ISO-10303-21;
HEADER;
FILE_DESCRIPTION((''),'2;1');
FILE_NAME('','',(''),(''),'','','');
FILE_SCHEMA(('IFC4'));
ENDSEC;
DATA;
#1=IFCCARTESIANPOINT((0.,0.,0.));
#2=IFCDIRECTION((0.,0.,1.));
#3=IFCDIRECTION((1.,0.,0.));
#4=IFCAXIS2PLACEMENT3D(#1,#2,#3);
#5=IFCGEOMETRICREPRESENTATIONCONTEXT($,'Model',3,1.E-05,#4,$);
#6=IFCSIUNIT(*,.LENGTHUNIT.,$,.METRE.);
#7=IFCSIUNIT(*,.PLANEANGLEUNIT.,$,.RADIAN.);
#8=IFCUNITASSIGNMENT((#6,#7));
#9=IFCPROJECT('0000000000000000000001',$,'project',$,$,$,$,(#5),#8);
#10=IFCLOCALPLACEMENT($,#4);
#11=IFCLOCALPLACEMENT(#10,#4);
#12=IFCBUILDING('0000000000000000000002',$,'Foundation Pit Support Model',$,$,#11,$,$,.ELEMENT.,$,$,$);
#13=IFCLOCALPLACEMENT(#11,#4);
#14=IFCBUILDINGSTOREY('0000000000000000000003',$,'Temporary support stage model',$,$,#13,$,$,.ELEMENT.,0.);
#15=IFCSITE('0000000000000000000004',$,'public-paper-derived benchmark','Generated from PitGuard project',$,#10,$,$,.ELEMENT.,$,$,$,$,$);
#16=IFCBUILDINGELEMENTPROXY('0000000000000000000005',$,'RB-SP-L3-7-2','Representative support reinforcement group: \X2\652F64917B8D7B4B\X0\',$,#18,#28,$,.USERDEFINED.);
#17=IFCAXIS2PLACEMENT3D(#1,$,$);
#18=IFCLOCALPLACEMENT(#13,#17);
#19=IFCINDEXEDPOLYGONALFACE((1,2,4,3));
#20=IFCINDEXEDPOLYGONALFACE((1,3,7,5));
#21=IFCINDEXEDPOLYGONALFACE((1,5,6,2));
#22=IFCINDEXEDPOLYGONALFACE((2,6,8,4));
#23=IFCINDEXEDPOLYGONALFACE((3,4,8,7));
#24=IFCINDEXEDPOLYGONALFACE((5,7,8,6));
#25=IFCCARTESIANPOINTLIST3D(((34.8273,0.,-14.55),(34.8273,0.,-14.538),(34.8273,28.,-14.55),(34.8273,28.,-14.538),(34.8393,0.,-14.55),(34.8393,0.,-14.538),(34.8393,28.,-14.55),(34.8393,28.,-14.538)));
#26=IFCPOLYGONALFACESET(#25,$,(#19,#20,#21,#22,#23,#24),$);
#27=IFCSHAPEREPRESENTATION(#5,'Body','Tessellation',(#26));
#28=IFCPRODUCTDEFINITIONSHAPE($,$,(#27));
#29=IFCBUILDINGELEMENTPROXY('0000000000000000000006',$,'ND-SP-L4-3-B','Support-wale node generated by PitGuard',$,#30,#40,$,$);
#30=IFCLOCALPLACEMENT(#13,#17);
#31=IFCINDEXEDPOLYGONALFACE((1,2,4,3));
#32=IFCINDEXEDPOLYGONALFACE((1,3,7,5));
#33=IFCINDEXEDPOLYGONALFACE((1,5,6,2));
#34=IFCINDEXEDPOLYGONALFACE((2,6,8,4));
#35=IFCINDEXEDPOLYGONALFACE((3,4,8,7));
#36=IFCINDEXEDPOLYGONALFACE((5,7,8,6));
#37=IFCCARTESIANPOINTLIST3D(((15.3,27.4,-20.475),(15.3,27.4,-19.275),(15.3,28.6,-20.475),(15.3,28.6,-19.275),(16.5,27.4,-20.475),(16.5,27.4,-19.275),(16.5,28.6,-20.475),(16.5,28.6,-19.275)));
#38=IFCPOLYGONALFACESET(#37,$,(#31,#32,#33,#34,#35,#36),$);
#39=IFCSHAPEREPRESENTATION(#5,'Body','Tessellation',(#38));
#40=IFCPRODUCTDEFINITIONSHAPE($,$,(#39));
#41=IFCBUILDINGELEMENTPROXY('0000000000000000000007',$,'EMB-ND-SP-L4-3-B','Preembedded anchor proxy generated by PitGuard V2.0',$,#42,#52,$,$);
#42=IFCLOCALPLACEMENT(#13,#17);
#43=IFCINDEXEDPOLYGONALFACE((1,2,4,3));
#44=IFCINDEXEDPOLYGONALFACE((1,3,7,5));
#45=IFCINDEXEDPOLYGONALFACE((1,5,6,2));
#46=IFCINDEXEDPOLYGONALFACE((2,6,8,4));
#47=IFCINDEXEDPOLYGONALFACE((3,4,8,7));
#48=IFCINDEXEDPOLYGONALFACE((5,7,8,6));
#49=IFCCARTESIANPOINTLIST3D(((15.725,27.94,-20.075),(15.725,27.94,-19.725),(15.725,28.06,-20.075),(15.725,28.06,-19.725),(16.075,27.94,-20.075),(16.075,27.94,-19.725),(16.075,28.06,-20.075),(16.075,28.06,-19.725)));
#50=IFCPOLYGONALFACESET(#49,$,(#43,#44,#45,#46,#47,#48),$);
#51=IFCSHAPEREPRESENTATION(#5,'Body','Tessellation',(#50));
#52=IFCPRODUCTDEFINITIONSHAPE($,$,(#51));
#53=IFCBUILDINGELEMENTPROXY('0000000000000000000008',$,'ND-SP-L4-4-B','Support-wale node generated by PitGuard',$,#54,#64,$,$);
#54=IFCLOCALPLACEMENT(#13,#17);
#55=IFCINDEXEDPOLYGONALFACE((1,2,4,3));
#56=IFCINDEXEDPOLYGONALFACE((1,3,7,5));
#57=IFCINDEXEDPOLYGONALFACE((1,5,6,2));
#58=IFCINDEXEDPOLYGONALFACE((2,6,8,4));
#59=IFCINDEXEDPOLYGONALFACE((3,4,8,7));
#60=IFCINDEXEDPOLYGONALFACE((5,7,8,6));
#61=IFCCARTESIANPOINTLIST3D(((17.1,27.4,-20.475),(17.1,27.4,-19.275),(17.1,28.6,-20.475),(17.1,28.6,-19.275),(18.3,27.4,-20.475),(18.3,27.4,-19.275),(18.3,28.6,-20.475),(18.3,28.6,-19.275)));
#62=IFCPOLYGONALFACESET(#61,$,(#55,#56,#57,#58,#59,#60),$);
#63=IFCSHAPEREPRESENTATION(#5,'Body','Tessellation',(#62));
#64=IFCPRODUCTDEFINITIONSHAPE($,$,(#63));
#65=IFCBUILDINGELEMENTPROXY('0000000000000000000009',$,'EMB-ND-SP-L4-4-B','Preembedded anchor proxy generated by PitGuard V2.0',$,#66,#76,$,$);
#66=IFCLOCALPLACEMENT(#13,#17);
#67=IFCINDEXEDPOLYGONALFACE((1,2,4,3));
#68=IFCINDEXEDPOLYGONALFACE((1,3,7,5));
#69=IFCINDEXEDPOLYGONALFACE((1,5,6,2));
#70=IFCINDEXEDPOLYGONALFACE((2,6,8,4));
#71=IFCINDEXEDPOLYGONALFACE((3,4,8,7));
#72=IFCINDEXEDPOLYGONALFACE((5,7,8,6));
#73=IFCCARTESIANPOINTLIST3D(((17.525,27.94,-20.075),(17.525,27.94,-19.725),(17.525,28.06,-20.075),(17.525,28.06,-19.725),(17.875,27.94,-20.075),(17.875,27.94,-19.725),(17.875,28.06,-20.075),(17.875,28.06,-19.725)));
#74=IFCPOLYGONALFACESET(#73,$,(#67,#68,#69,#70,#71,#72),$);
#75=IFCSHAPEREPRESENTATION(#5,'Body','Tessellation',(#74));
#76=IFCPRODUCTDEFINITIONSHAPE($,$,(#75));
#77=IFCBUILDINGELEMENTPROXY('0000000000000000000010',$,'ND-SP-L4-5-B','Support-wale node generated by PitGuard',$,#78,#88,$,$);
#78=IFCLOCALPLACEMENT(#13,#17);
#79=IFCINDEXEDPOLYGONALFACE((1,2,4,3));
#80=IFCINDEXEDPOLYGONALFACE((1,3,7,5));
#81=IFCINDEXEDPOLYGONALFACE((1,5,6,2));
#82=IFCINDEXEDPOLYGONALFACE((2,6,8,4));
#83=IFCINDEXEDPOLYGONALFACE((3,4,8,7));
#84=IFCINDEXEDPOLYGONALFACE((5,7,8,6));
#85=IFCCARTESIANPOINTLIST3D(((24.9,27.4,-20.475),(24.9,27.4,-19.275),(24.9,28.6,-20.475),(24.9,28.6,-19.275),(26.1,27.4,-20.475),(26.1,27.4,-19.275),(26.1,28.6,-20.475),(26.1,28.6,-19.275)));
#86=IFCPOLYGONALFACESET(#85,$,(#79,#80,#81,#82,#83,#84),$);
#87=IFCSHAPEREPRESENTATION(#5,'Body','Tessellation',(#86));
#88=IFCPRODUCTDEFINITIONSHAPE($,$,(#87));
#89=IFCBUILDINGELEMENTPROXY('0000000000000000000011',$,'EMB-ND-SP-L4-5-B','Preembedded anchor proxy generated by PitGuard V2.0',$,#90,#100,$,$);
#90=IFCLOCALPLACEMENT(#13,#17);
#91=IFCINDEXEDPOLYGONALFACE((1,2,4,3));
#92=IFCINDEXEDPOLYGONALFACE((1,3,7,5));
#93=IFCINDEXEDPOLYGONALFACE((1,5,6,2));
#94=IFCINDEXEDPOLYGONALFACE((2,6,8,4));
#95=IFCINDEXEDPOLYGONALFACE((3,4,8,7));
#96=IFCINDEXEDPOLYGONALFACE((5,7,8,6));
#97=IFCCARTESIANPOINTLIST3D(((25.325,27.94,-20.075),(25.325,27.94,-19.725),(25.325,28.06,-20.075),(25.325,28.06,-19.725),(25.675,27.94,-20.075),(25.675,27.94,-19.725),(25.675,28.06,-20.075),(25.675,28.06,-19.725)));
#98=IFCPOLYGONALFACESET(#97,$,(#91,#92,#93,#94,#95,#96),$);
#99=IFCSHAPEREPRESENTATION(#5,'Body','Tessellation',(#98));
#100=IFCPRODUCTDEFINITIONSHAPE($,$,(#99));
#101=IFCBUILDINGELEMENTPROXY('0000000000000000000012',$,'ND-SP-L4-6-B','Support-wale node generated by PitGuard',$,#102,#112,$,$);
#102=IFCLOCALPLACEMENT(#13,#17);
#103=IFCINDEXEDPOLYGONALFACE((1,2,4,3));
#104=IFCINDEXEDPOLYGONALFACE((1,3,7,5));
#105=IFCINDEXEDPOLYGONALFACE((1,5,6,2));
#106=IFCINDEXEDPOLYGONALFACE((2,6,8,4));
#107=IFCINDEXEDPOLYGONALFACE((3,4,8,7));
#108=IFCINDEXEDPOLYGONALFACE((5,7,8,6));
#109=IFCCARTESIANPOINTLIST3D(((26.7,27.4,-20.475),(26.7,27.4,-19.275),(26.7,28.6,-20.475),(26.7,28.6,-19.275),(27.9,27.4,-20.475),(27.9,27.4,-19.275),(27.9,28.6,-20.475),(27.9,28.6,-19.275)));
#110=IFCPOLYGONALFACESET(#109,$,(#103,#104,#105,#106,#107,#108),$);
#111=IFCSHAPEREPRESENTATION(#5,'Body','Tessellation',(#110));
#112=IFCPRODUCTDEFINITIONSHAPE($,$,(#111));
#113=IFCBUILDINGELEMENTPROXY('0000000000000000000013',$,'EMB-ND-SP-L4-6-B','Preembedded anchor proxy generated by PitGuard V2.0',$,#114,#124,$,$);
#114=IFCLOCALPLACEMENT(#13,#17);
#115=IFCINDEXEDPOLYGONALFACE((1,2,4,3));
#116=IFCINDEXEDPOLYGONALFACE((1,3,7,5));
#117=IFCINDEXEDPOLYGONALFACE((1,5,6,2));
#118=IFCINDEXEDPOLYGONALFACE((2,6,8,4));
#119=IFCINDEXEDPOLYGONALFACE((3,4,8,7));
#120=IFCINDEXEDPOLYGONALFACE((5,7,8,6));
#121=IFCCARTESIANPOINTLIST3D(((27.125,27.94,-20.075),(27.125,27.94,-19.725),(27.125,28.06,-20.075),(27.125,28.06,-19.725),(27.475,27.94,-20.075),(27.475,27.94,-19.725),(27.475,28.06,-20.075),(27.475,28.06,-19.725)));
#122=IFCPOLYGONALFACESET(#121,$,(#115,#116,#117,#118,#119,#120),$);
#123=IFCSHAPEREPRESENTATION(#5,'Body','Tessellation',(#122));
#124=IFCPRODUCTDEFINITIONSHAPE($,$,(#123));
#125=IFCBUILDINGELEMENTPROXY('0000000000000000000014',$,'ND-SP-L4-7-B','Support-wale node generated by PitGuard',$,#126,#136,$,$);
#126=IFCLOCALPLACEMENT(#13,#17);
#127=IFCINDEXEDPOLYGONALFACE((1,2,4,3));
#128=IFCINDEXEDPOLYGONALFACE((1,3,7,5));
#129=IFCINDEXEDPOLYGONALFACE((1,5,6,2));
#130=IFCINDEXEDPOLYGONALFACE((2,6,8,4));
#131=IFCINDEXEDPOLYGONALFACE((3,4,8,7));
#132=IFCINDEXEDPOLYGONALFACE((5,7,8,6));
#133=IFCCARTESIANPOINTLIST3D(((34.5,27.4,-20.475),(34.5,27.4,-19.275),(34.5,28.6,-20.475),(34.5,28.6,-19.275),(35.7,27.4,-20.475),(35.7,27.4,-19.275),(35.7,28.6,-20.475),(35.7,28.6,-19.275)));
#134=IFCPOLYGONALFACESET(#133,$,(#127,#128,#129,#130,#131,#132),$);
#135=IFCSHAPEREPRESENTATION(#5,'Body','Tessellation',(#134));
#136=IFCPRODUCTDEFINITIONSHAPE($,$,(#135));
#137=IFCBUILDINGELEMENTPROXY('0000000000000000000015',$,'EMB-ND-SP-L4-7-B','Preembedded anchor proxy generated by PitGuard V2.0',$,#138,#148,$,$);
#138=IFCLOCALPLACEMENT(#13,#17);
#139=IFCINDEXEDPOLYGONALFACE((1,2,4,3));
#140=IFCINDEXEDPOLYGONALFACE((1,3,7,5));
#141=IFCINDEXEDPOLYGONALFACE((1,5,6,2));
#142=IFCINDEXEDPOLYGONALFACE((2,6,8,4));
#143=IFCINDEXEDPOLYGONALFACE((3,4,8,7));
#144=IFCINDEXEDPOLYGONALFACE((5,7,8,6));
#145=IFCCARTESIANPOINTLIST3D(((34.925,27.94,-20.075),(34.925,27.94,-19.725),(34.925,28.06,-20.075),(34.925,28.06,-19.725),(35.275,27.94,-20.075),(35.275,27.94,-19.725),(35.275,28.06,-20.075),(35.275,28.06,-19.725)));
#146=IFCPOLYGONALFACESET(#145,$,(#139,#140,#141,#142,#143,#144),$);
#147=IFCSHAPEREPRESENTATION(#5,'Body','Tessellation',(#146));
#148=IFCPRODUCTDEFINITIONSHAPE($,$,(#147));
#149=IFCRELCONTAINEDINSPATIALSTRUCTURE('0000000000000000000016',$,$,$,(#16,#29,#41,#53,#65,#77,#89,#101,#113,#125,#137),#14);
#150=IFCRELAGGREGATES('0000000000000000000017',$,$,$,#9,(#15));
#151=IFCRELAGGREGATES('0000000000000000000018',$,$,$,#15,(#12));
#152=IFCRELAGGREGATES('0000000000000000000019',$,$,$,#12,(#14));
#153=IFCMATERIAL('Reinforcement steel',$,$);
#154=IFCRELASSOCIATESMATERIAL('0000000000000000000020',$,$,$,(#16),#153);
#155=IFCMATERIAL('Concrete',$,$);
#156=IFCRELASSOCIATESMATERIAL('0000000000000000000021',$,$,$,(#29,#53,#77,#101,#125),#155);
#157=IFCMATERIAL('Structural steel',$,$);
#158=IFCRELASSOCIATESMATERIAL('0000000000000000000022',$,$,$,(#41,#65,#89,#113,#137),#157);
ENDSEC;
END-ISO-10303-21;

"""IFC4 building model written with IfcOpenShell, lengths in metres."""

from ifc_helpers import new_model, si_unit, frame, origin_with_axes, origin_2d, place, context, project, spatial, rectangle, extrude, material, element, save


model = new_model("IFC4")

# Units and contexts
model_context = context("Model", 3, precision=1e-05, world=origin_with_axes())
ifc_project = project(units=[si_unit("LENGTHUNIT", "METRE"), si_unit("PLANEANGLEUNIT", "RADIAN")], contexts=[model_context])

# Site, building, storey
site_placement = place(None, origin_with_axes())
site = spatial("IfcSite", under=ifc_project, at=site_placement, Name="public-paper-derived benchmark", Description="Generated from PitGuard project", CompositionType="ELEMENT")
building_placement = place(site_placement, origin_with_axes())
building = spatial("IfcBuilding", under=site, at=building_placement, Name="Foundation Pit Support Model", CompositionType="ELEMENT")
storey_placement = place(building_placement, origin_with_axes())
storey = spatial("IfcBuildingStorey", under=building, at=storey_placement, Name="Temporary support stage model", CompositionType="ELEMENT", Elevation=0.0)

# Shared definitions
ifc_material_1 = material(Name="Concrete")

# Shared definitions
ifc_material_2 = material(Name="Structural steel")

# Building element proxies
ifc_material_3 = material(Name="Reinforcement steel")
proxy_1_placement = place(storey_placement, frame((34.8333, 14.0, -14.55), z_axis=(0.0, 0.0, 1.0), x_axis=(0.0, 1.0, 0.0)))
element("IfcBuildingElementProxy", 1, at=proxy_1_placement, inside=storey, material=ifc_material_3, Name="RB-SP-L3-7-2", Description="Representative support reinforcement group: 支撑箍筋", PredefinedType="USERDEFINED", context=model_context, shape_type="SweptSolid", body=[
    extrude(rectangle(XDim=28.0, YDim=0.012, at=origin_2d()), origin_with_axes(), (0.0, 0.0, 1.0), 0.012),
])
proxy_2_placement = place(storey_placement, frame((15.9, 28.0, -20.475), z_axis=(0.0, 0.0, 1.0), x_axis=(1.0, 0.0, 0.0)))
element("IfcBuildingElementProxy", 2, at=proxy_2_placement, inside=storey, material=ifc_material_1, Name="ND-SP-L4-3-B", Description="Support-wale node generated by PitGuard", context=model_context, shape_type="SweptSolid", body=[
    extrude(rectangle(XDim=1.2, YDim=1.2, at=origin_2d()), origin_with_axes(), (0.0, 0.0, 1.0), 1.2),
])
proxy_3_placement = place(storey_placement, frame((15.9, 28.0, -20.075), z_axis=(0.0, 0.0, 1.0), x_axis=(1.0, 0.0, 0.0)))
element("IfcBuildingElementProxy", 3, at=proxy_3_placement, inside=storey, material=ifc_material_2, Name="EMB-ND-SP-L4-3-B", Description="Preembedded anchor proxy generated by PitGuard V2.0", context=model_context, shape_type="SweptSolid", body=[
    extrude(rectangle(XDim=0.35, YDim=0.12, at=origin_2d()), origin_with_axes(), (0.0, 0.0, 1.0), 0.35),
])
proxy_4_placement = place(storey_placement, frame((17.7, 28.0, -20.475), z_axis=(0.0, 0.0, 1.0), x_axis=(1.0, 0.0, 0.0)))
element("IfcBuildingElementProxy", 4, at=proxy_4_placement, inside=storey, material=ifc_material_1, Name="ND-SP-L4-4-B", Description="Support-wale node generated by PitGuard", context=model_context, shape_type="SweptSolid", body=[
    extrude(rectangle(XDim=1.2, YDim=1.2, at=origin_2d()), origin_with_axes(), (0.0, 0.0, 1.0), 1.2),
])
proxy_5_placement = place(storey_placement, frame((17.7, 28.0, -20.075), z_axis=(0.0, 0.0, 1.0), x_axis=(1.0, 0.0, 0.0)))
element("IfcBuildingElementProxy", 5, at=proxy_5_placement, inside=storey, material=ifc_material_2, Name="EMB-ND-SP-L4-4-B", Description="Preembedded anchor proxy generated by PitGuard V2.0", context=model_context, shape_type="SweptSolid", body=[
    extrude(rectangle(XDim=0.35, YDim=0.12, at=origin_2d()), origin_with_axes(), (0.0, 0.0, 1.0), 0.35),
])
proxy_6_placement = place(storey_placement, frame((25.5, 28.0, -20.475), z_axis=(0.0, 0.0, 1.0), x_axis=(1.0, 0.0, 0.0)))
element("IfcBuildingElementProxy", 6, at=proxy_6_placement, inside=storey, material=ifc_material_1, Name="ND-SP-L4-5-B", Description="Support-wale node generated by PitGuard", context=model_context, shape_type="SweptSolid", body=[
    extrude(rectangle(XDim=1.2, YDim=1.2, at=origin_2d()), origin_with_axes(), (0.0, 0.0, 1.0), 1.2),
])
proxy_7_placement = place(storey_placement, frame((25.5, 28.0, -20.075), z_axis=(0.0, 0.0, 1.0), x_axis=(1.0, 0.0, 0.0)))
element("IfcBuildingElementProxy", 7, at=proxy_7_placement, inside=storey, material=ifc_material_2, Name="EMB-ND-SP-L4-5-B", Description="Preembedded anchor proxy generated by PitGuard V2.0", context=model_context, shape_type="SweptSolid", body=[
    extrude(rectangle(XDim=0.35, YDim=0.12, at=origin_2d()), origin_with_axes(), (0.0, 0.0, 1.0), 0.35),
])
proxy_8_placement = place(storey_placement, frame((27.3, 28.0, -20.475), z_axis=(0.0, 0.0, 1.0), x_axis=(1.0, 0.0, 0.0)))
element("IfcBuildingElementProxy", 8, at=proxy_8_placement, inside=storey, material=ifc_material_1, Name="ND-SP-L4-6-B", Description="Support-wale node generated by PitGuard", context=model_context, shape_type="SweptSolid", body=[
    extrude(rectangle(XDim=1.2, YDim=1.2, at=origin_2d()), origin_with_axes(), (0.0, 0.0, 1.0), 1.2),
])
proxy_9_placement = place(storey_placement, frame((27.3, 28.0, -20.075), z_axis=(0.0, 0.0, 1.0), x_axis=(1.0, 0.0, 0.0)))
element("IfcBuildingElementProxy", 9, at=proxy_9_placement, inside=storey, material=ifc_material_2, Name="EMB-ND-SP-L4-6-B", Description="Preembedded anchor proxy generated by PitGuard V2.0", context=model_context, shape_type="SweptSolid", body=[
    extrude(rectangle(XDim=0.35, YDim=0.12, at=origin_2d()), origin_with_axes(), (0.0, 0.0, 1.0), 0.35),
])
proxy_10_placement = place(storey_placement, frame((35.1, 28.0, -20.475), z_axis=(0.0, 0.0, 1.0), x_axis=(1.0, 0.0, 0.0)))
element("IfcBuildingElementProxy", 10, at=proxy_10_placement, inside=storey, material=ifc_material_1, Name="ND-SP-L4-7-B", Description="Support-wale node generated by PitGuard", context=model_context, shape_type="SweptSolid", body=[
    extrude(rectangle(XDim=1.2, YDim=1.2, at=origin_2d()), origin_with_axes(), (0.0, 0.0, 1.0), 1.2),
])
proxy_11_placement = place(storey_placement, frame((35.1, 28.0, -20.075), z_axis=(0.0, 0.0, 1.0), x_axis=(1.0, 0.0, 0.0)))
element("IfcBuildingElementProxy", 11, at=proxy_11_placement, inside=storey, material=ifc_material_2, Name="EMB-ND-SP-L4-7-B", Description="Preembedded anchor proxy generated by PitGuard V2.0", context=model_context, shape_type="SweptSolid", body=[
    extrude(rectangle(XDim=0.35, YDim=0.12, at=origin_2d()), origin_with_axes(), (0.0, 0.0, 1.0), 0.35),
])

save(model, "model.ifc")
